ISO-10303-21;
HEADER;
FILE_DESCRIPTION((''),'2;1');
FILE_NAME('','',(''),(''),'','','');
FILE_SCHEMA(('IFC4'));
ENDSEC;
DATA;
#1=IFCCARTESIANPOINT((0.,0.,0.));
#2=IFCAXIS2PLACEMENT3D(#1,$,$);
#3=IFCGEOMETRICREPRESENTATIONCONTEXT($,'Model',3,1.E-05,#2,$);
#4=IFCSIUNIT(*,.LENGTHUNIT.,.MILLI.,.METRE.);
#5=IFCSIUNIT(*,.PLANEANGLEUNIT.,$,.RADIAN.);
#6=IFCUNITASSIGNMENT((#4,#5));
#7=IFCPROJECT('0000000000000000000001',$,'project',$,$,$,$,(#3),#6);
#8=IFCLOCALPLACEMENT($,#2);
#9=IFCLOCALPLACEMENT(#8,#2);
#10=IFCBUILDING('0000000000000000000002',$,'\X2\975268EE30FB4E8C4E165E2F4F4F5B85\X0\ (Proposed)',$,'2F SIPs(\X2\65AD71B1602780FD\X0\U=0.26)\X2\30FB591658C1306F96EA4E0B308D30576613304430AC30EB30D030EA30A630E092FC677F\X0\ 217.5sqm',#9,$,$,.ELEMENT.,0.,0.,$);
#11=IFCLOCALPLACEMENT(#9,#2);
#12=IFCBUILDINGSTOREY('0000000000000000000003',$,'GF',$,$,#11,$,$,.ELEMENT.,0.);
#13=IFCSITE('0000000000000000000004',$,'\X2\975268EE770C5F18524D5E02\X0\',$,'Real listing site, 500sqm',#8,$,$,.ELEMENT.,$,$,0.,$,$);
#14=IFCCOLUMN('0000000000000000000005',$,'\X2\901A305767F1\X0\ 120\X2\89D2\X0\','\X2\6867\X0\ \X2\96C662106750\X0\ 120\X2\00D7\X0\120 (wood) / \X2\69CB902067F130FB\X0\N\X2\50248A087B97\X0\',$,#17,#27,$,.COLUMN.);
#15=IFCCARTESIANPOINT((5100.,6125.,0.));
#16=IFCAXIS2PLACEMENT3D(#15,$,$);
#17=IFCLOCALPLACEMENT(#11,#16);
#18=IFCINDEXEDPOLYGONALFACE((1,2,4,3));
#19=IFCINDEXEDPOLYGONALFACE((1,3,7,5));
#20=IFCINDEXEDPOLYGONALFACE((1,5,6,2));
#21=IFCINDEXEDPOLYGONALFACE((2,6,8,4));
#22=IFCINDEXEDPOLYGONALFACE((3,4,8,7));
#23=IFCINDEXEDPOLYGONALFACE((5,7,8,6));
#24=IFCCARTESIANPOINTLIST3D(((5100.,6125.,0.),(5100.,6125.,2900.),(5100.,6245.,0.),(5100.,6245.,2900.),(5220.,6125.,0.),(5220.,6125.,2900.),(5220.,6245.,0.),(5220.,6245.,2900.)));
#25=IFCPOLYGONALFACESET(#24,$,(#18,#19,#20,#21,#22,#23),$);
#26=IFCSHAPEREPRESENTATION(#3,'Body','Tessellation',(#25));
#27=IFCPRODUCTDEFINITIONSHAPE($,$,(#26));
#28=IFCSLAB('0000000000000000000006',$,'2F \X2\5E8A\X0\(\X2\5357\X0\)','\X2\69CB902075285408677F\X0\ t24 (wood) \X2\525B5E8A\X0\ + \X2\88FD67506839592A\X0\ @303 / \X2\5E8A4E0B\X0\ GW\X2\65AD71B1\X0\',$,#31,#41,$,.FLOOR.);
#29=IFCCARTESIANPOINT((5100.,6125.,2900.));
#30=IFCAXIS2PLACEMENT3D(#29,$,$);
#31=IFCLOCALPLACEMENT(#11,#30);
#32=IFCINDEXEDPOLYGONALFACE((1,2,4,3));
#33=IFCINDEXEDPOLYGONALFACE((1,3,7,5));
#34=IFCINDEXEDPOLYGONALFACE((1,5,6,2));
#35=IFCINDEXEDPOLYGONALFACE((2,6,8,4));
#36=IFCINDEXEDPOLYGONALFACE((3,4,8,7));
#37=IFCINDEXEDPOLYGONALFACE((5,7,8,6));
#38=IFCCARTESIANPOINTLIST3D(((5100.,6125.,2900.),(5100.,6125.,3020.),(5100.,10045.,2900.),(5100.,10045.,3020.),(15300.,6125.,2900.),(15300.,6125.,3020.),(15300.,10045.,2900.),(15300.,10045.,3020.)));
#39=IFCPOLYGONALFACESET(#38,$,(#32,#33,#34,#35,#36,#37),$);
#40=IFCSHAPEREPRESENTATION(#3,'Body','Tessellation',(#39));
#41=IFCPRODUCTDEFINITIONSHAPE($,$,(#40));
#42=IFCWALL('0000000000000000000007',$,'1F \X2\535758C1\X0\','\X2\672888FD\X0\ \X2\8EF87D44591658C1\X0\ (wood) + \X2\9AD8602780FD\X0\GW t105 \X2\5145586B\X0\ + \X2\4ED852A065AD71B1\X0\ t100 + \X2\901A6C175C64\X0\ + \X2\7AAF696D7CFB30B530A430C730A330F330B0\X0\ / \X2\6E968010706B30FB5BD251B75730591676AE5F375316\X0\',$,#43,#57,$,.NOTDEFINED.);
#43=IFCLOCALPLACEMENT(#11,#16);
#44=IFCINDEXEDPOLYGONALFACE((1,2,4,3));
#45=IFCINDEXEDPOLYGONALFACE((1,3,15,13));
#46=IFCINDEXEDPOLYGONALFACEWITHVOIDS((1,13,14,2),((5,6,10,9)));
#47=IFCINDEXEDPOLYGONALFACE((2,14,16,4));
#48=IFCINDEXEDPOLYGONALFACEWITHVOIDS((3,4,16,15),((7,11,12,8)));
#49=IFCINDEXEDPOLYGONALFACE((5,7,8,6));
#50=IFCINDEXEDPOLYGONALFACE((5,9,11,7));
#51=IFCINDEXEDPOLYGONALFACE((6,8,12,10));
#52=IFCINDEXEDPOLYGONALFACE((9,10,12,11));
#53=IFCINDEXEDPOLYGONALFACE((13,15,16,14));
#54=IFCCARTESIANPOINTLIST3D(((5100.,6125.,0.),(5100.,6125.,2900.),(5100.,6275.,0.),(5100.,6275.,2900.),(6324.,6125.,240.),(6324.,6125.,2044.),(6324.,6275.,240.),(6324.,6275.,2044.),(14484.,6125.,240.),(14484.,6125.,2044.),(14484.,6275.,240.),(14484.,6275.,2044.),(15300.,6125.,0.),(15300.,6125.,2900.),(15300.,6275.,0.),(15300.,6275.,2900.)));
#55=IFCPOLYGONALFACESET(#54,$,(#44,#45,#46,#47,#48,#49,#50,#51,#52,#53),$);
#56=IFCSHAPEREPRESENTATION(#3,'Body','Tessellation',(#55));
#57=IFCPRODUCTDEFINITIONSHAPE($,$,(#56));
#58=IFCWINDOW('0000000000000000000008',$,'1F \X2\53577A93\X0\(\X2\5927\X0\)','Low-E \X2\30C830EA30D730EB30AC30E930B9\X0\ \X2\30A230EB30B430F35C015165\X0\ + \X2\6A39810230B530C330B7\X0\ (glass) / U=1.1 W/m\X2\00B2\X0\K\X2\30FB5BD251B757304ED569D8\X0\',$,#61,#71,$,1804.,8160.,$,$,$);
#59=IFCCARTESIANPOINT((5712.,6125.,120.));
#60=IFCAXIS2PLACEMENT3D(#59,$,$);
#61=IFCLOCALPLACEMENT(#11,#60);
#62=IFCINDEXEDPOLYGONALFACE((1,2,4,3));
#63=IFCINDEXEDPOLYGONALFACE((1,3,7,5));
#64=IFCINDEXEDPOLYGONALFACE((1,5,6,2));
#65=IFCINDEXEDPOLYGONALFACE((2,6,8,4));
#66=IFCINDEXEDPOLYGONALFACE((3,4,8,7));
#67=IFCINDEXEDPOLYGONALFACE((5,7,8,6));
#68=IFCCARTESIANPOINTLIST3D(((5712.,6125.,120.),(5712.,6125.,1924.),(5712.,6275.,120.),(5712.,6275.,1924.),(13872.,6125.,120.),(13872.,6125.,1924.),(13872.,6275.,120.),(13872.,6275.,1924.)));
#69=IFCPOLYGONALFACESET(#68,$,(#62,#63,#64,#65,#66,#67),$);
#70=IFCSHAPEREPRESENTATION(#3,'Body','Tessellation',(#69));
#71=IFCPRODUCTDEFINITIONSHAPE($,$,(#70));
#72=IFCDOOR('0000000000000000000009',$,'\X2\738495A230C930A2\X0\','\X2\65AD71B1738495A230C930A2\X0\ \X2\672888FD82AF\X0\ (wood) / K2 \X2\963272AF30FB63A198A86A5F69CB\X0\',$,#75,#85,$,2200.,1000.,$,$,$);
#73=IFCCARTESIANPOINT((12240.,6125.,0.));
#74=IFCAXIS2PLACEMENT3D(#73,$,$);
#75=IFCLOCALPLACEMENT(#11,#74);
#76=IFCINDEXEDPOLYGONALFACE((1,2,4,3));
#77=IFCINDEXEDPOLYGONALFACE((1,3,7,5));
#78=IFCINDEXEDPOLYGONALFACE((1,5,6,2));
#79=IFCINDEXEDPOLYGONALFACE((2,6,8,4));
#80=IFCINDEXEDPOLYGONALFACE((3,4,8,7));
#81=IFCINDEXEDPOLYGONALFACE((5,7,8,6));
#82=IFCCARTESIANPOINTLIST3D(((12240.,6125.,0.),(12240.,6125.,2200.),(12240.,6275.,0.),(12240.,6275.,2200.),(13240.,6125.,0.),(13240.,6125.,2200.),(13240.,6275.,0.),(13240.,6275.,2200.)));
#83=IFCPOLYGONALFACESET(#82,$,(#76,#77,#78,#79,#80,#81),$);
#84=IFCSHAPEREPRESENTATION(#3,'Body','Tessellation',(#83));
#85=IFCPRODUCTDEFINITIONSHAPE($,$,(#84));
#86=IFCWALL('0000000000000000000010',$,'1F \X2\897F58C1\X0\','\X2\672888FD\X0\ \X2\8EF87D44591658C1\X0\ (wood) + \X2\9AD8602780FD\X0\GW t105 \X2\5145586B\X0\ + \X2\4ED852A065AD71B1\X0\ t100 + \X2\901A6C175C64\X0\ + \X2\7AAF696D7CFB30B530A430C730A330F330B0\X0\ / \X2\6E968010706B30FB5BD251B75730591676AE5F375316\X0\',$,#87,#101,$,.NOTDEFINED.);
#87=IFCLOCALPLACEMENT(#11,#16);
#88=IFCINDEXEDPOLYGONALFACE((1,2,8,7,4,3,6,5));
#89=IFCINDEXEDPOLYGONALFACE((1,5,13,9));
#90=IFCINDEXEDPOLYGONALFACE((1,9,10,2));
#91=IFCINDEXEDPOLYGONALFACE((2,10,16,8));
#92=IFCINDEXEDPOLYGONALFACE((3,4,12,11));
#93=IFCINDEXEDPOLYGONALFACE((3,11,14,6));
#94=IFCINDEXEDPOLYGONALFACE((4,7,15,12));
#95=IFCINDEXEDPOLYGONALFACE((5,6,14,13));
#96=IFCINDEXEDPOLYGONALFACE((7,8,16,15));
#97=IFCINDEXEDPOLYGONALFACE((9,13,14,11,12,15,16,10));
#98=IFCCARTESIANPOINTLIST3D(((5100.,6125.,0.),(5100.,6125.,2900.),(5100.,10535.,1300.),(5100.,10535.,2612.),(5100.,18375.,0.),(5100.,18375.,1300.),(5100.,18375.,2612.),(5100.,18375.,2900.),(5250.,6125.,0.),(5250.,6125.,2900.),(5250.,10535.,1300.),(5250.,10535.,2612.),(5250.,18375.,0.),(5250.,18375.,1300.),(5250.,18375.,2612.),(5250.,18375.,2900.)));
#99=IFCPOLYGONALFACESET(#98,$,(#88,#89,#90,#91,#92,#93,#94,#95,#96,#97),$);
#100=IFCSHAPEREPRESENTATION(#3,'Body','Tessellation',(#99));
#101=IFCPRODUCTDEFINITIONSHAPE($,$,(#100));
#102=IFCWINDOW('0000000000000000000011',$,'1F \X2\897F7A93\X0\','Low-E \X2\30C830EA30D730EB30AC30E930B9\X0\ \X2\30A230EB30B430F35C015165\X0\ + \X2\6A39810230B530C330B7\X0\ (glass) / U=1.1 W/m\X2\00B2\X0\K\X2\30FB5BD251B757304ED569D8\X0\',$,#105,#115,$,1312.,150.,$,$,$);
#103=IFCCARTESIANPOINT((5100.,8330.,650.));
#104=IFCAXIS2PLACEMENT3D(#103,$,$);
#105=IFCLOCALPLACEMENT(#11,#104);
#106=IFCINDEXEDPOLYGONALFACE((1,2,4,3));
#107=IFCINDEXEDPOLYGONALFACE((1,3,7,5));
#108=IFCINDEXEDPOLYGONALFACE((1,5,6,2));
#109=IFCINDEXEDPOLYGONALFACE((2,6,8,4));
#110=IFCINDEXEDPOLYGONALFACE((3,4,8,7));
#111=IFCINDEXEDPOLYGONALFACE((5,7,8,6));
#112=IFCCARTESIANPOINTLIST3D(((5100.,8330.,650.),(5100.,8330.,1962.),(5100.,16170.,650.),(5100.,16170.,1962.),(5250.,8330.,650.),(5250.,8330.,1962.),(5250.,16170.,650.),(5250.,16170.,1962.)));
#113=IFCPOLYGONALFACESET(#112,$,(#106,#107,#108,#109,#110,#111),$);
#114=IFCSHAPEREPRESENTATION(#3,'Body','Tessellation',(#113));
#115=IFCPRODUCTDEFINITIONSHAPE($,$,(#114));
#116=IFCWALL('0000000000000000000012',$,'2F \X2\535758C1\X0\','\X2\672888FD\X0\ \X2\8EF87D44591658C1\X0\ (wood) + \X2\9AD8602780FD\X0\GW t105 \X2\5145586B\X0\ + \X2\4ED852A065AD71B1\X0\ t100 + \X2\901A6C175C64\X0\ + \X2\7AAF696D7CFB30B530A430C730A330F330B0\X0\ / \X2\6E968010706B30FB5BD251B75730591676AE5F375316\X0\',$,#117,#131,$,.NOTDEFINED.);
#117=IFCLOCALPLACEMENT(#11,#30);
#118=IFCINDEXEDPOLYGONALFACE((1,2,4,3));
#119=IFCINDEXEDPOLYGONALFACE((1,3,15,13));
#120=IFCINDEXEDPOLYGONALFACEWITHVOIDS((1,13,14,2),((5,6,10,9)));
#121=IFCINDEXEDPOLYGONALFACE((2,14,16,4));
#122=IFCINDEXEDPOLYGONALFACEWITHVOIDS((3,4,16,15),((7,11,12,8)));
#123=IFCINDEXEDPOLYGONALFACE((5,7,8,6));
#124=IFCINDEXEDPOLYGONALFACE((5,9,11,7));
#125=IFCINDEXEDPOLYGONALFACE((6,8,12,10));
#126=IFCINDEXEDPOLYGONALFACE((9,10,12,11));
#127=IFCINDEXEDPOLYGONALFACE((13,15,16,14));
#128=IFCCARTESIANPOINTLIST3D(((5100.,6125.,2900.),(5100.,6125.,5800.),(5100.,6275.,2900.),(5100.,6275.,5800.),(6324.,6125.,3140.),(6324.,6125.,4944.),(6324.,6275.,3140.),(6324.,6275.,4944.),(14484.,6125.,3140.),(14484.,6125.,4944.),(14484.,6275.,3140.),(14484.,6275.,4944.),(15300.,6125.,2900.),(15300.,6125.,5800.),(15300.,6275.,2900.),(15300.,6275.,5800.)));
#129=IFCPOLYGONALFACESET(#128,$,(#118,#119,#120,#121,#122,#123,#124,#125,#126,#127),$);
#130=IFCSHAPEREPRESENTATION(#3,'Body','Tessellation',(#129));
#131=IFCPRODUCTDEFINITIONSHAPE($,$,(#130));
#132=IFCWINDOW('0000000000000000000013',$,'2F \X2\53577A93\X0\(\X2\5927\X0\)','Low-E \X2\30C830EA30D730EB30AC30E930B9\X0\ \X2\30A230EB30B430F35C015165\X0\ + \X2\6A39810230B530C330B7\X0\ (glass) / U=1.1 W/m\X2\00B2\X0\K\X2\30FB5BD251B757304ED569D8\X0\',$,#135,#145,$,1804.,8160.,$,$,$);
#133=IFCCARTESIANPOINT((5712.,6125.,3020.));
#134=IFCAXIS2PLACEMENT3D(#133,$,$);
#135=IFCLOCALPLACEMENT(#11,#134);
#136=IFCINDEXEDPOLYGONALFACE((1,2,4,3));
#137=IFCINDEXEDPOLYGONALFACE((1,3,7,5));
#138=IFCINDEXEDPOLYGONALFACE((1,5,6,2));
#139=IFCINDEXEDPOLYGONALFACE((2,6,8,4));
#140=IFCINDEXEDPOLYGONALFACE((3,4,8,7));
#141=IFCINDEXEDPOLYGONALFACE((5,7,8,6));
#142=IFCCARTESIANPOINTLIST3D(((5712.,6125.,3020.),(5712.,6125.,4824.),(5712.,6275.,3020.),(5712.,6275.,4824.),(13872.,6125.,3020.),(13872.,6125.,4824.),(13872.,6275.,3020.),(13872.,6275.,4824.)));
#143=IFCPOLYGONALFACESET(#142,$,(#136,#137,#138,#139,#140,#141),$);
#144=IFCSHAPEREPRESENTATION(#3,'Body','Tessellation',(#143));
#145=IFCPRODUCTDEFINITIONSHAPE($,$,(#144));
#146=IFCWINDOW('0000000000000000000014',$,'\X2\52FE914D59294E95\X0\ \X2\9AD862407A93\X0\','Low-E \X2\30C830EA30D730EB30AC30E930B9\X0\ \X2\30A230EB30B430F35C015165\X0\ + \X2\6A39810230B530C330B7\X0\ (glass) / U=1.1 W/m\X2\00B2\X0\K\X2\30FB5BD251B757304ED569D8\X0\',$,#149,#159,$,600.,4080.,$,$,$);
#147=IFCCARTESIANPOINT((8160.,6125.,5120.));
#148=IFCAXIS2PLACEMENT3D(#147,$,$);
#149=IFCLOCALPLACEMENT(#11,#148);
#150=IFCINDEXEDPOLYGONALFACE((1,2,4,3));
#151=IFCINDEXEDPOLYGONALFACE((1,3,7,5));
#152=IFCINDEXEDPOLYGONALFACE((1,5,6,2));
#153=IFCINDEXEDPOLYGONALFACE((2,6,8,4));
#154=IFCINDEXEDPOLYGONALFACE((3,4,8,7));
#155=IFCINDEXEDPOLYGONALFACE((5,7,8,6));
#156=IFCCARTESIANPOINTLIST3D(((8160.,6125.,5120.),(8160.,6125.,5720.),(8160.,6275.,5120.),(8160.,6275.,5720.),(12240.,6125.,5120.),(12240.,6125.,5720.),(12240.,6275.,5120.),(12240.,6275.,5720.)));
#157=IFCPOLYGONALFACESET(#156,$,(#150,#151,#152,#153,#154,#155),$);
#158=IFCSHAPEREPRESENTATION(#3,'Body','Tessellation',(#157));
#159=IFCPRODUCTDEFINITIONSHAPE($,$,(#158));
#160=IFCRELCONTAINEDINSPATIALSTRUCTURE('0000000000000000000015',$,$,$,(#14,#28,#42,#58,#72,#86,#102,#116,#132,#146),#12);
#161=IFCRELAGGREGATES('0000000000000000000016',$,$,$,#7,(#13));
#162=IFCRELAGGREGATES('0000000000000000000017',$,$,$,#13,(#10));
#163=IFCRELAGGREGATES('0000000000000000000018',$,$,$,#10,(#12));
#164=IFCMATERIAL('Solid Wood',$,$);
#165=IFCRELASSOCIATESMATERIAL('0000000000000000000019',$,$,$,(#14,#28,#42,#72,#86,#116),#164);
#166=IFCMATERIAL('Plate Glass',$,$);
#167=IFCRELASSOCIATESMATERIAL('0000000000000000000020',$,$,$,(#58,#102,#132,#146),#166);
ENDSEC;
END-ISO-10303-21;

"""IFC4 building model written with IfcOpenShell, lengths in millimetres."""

from ifc_helpers import new_model, si_unit, frame, frame_2d, origin, place, context, project, spatial, rectangle, extrude, material, element, fill, save


model = new_model("IFC4")

# Units and contexts
model_context = context("Model", 3, precision=1e-05, world=origin())
ifc_project = project(units=[si_unit("LENGTHUNIT", "METRE", prefix="MILLI"), si_unit("PLANEANGLEUNIT", "RADIAN")], contexts=[model_context])

# Site, building, storey
site_placement = place(None, origin())
site = spatial("IfcSite", under=ifc_project, at=site_placement, Name="青森県弘前市", ObjectType="Real listing site, 500sqm", CompositionType="ELEMENT", RefElevation=0.0)
building_placement = place(site_placement, origin())
building = spatial("IfcBuilding", under=site, at=building_placement, Name="青森・二世帯住宅 (Proposed)", ObjectType="2F SIPs(断熱性能U=0.26)・外壁は雪下ろし易いガルバリウム鋼板 217.5sqm", CompositionType="ELEMENT", ElevationOfRefHeight=0.0, ElevationOfTerrain=0.0)
storey_placement = place(building_placement, origin())
storey = spatial("IfcBuildingStorey", under=building, at=storey_placement, Name="GF", CompositionType="ELEMENT", Elevation=0.0)

# Column
ifc_material_1 = material(Name="Solid Wood")
column_placement = place(storey_placement, frame((5100.0, 6125.0, 0.0)))
element("IfcColumn", 1, at=column_placement, inside=storey, material=ifc_material_1, Name="通し柱 120角", Description="桧 集成材 120×120 (wood) / 構造柱・N値計算", PredefinedType="COLUMN", context=model_context, shape_type="SweptSolid", body=[
    extrude(rectangle(XDim=120.0, YDim=120.0, at=frame_2d((60.0, 60.0))), frame((5100.0, 6125.0, 0.0)), (0.0, 0.0, 1.0), 2900.0),
])

# Slab
slab_1_placement = place(storey_placement, frame((5100.0, 6125.0, 2900.0)))
element("IfcSlab", 2, at=slab_1_placement, inside=storey, material=ifc_material_1, Name="2F 床(南)", Description="構造用合板 t24 (wood) 剛床 + 製材根太 @303 / 床下 GW断熱", PredefinedType="FLOOR", context=model_context, shape_type="SweptSolid", body=[
    extrude(rectangle(XDim=10200.0, YDim=3920.0, at=frame_2d((5100.0, 1960.0))), frame((5100.0, 6125.0, 2900.0)), (0.0, 0.0, 1.0), 120.0),
])

# Wall, openings, window, door
wall_1_placement = place(storey_placement, frame((5100.0, 6125.0, 0.0)))
wall_1 = element("IfcWall", 3, at=wall_1_placement, inside=storey, material=ifc_material_1, Name="1F 南壁", Description="木製 軸組外壁 (wood) + 高性能GW t105 充填 + 付加断熱 t100 + 通気層 + 窯業系サイディング / 準耐火・寒冷地外皮強化", PredefinedType="NOTDEFINED", context=model_context, shape_type="SweptSolid", body=[
    extrude(rectangle(XDim=10200.0, YDim=150.0, at=frame_2d((5100.0, 75.0))), frame((5100.0, 6125.0, 0.0)), (0.0, 0.0, 1.0), 2900.0),
])
opening_1_placement = place(storey_placement, frame((5712.0, 6125.0, 120.0)))
opening_1 = element("IfcOpeningElement", 4, at=opening_1_placement, cuts=wall_1, PredefinedType="NOTDEFINED", context=model_context, shape_type="SweptSolid", body=[
    extrude(rectangle(XDim=8160.0, YDim=150.0, at=frame_2d((4080.0, 75.0))), frame((5712.0, 6125.0, 120.0)), (0.0, 0.0, 1.0), 1804.0),
])
opening_2_placement = place(storey_placement, frame((12240.0, 6125.0, 0.0)))
opening_2 = element("IfcOpeningElement", 5, at=opening_2_placement, cuts=wall_1, PredefinedType="NOTDEFINED", context=model_context, shape_type="SweptSolid", body=[
    extrude(rectangle(XDim=1000.0, YDim=150.0, at=frame_2d((500.0, 75.0))), frame((12240.0, 6125.0, 0.0)), (0.0, 0.0, 1.0), 2200.0),
])
ifc_material_2 = material(Name="Plate Glass")
window_1_placement = place(storey_placement, frame((5712.0, 6125.0, 120.0)))
window_1 = element("IfcWindow", 6, at=window_1_placement, inside=storey, material=ifc_material_2, Name="1F 南窓(大)", Description="Low-E トリプルガラス アルゴン封入 + 樹脂サッシ (glass) / U=1.1 W/m²K・寒冷地仕様", OverallHeight=1804.0, OverallWidth=8160.0, context=model_context, shape_type="SweptSolid", body=[
    extrude(rectangle(XDim=8160.0, YDim=150.0, at=frame_2d((4080.0, 75.0))), frame((5712.0, 6125.0, 120.0)), (0.0, 0.0, 1.0), 1804.0),
])
fill(opening_1, window_1)
door_placement = place(storey_placement, frame((12240.0, 6125.0, 0.0)))
door = element("IfcDoor", 7, at=door_placement, inside=storey, material=ifc_material_1, Name="玄関ドア", Description="断熱玄関ドア 木製芯 (wood) / K2 防犯・採風機構", OverallHeight=2200.0, OverallWidth=1000.0, context=model_context, shape_type="SweptSolid", body=[
    extrude(rectangle(XDim=1000.0, YDim=150.0, at=frame_2d((500.0, 75.0))), frame((12240.0, 6125.0, 0.0)), (0.0, 0.0, 1.0), 2200.0),
])
fill(opening_2, door)

# Wall, opening, window
wall_2_placement = place(storey_placement, frame((5100.0, 6125.0, 0.0)))
wall_2 = element("IfcWall", 8, at=wall_2_placement, inside=storey, material=ifc_material_1, Name="1F 西壁", Description="木製 軸組外壁 (wood) + 高性能GW t105 充填 + 付加断熱 t100 + 通気層 + 窯業系サイディング / 準耐火・寒冷地外皮強化", PredefinedType="NOTDEFINED", context=model_context, shape_type="SweptSolid", body=[
    extrude(rectangle(XDim=150.0, YDim=12250.0, at=frame_2d((75.0, 6125.0))), frame((5100.0, 6125.0, 0.0)), (0.0, 0.0, 1.0), 2900.0),
])
opening_3_placement = place(storey_placement, frame((5100.0, 8330.0, 650.0)))
opening_3 = element("IfcOpeningElement", 9, at=opening_3_placement, cuts=wall_2, PredefinedType="NOTDEFINED", context=model_context, shape_type="SweptSolid", body=[
    extrude(rectangle(XDim=150.0, YDim=7840.0, at=frame_2d((75.0, 3920.0))), frame((5100.0, 8330.0, 650.0)), (0.0, 0.0, 1.0), 1312.0),
])
window_2_placement = place(storey_placement, frame((5100.0, 8330.0, 650.0)))
window_2 = element("IfcWindow", 10, at=window_2_placement, inside=storey, material=ifc_material_2, Name="1F 西窓", Description="Low-E トリプルガラス アルゴン封入 + 樹脂サッシ (glass) / U=1.1 W/m²K・寒冷地仕様", OverallHeight=1312.0, OverallWidth=150.0, context=model_context, shape_type="SweptSolid", body=[
    extrude(rectangle(XDim=150.0, YDim=7840.0, at=frame_2d((75.0, 3920.0))), frame((5100.0, 8330.0, 650.0)), (0.0, 0.0, 1.0), 1312.0),
])
fill(opening_3, window_2)

# Wall, openings, windows
wall_3_placement = place(storey_placement, frame((5100.0, 6125.0, 2900.0)))
wall_3 = element("IfcWall", 11, at=wall_3_placement, inside=storey, material=ifc_material_1, Name="2F 南壁", Description="木製 軸組外壁 (wood) + 高性能GW t105 充填 + 付加断熱 t100 + 通気層 + 窯業系サイディング / 準耐火・寒冷地外皮強化", PredefinedType="NOTDEFINED", context=model_context, shape_type="SweptSolid", body=[
    extrude(rectangle(XDim=10200.0, YDim=150.0, at=frame_2d((5100.0, 75.0))), frame((5100.0, 6125.0, 2900.0)), (0.0, 0.0, 1.0), 2900.0),
])
opening_4_placement = place(storey_placement, frame((5712.0, 6125.0, 3020.0)))
opening_4 = element("IfcOpeningElement", 12, at=opening_4_placement, cuts=wall_3, PredefinedType="NOTDEFINED", context=model_context, shape_type="SweptSolid", body=[
    extrude(rectangle(XDim=8160.0, YDim=150.0, at=frame_2d((4080.0, 75.0))), frame((5712.0, 6125.0, 3020.0)), (0.0, 0.0, 1.0), 1804.0),
])
opening_5_placement = place(storey_placement, frame((8160.0, 6125.0, 5120.0)))
opening_5 = element("IfcOpeningElement", 13, at=opening_5_placement, cuts=wall_3, PredefinedType="NOTDEFINED", context=model_context, shape_type="SweptSolid", body=[
    extrude(rectangle(XDim=4080.0, YDim=150.0, at=frame_2d((2040.0, 75.0))), frame((8160.0, 6125.0, 5120.0)), (0.0, 0.0, 1.0), 600.0),
])
window_3_placement = place(storey_placement, frame((5712.0, 6125.0, 3020.0)))
window_3 = element("IfcWindow", 14, at=window_3_placement, inside=storey, material=ifc_material_2, Name="2F 南窓(大)", Description="Low-E トリプルガラス アルゴン封入 + 樹脂サッシ (glass) / U=1.1 W/m²K・寒冷地仕様", OverallHeight=1804.0, OverallWidth=8160.0, context=model_context, shape_type="SweptSolid", body=[
    extrude(rectangle(XDim=8160.0, YDim=150.0, at=frame_2d((4080.0, 75.0))), frame((5712.0, 6125.0, 3020.0)), (0.0, 0.0, 1.0), 1804.0),
])
fill(opening_4, window_3)
window_4_placement = place(storey_placement, frame((8160.0, 6125.0, 5120.0)))
window_4 = element("IfcWindow", 15, at=window_4_placement, inside=storey, material=ifc_material_2, Name="勾配天井 高所窓", Description="Low-E トリプルガラス アルゴン封入 + 樹脂サッシ (glass) / U=1.1 W/m²K・寒冷地仕様", OverallHeight=600.0, OverallWidth=4080.0, context=model_context, shape_type="SweptSolid", body=[
    extrude(rectangle(XDim=4080.0, YDim=150.0, at=frame_2d((2040.0, 75.0))), frame((8160.0, 6125.0, 5120.0)), (0.0, 0.0, 1.0), 600.0),
])
fill(opening_5, window_4)

save(model, "model.ifc")
